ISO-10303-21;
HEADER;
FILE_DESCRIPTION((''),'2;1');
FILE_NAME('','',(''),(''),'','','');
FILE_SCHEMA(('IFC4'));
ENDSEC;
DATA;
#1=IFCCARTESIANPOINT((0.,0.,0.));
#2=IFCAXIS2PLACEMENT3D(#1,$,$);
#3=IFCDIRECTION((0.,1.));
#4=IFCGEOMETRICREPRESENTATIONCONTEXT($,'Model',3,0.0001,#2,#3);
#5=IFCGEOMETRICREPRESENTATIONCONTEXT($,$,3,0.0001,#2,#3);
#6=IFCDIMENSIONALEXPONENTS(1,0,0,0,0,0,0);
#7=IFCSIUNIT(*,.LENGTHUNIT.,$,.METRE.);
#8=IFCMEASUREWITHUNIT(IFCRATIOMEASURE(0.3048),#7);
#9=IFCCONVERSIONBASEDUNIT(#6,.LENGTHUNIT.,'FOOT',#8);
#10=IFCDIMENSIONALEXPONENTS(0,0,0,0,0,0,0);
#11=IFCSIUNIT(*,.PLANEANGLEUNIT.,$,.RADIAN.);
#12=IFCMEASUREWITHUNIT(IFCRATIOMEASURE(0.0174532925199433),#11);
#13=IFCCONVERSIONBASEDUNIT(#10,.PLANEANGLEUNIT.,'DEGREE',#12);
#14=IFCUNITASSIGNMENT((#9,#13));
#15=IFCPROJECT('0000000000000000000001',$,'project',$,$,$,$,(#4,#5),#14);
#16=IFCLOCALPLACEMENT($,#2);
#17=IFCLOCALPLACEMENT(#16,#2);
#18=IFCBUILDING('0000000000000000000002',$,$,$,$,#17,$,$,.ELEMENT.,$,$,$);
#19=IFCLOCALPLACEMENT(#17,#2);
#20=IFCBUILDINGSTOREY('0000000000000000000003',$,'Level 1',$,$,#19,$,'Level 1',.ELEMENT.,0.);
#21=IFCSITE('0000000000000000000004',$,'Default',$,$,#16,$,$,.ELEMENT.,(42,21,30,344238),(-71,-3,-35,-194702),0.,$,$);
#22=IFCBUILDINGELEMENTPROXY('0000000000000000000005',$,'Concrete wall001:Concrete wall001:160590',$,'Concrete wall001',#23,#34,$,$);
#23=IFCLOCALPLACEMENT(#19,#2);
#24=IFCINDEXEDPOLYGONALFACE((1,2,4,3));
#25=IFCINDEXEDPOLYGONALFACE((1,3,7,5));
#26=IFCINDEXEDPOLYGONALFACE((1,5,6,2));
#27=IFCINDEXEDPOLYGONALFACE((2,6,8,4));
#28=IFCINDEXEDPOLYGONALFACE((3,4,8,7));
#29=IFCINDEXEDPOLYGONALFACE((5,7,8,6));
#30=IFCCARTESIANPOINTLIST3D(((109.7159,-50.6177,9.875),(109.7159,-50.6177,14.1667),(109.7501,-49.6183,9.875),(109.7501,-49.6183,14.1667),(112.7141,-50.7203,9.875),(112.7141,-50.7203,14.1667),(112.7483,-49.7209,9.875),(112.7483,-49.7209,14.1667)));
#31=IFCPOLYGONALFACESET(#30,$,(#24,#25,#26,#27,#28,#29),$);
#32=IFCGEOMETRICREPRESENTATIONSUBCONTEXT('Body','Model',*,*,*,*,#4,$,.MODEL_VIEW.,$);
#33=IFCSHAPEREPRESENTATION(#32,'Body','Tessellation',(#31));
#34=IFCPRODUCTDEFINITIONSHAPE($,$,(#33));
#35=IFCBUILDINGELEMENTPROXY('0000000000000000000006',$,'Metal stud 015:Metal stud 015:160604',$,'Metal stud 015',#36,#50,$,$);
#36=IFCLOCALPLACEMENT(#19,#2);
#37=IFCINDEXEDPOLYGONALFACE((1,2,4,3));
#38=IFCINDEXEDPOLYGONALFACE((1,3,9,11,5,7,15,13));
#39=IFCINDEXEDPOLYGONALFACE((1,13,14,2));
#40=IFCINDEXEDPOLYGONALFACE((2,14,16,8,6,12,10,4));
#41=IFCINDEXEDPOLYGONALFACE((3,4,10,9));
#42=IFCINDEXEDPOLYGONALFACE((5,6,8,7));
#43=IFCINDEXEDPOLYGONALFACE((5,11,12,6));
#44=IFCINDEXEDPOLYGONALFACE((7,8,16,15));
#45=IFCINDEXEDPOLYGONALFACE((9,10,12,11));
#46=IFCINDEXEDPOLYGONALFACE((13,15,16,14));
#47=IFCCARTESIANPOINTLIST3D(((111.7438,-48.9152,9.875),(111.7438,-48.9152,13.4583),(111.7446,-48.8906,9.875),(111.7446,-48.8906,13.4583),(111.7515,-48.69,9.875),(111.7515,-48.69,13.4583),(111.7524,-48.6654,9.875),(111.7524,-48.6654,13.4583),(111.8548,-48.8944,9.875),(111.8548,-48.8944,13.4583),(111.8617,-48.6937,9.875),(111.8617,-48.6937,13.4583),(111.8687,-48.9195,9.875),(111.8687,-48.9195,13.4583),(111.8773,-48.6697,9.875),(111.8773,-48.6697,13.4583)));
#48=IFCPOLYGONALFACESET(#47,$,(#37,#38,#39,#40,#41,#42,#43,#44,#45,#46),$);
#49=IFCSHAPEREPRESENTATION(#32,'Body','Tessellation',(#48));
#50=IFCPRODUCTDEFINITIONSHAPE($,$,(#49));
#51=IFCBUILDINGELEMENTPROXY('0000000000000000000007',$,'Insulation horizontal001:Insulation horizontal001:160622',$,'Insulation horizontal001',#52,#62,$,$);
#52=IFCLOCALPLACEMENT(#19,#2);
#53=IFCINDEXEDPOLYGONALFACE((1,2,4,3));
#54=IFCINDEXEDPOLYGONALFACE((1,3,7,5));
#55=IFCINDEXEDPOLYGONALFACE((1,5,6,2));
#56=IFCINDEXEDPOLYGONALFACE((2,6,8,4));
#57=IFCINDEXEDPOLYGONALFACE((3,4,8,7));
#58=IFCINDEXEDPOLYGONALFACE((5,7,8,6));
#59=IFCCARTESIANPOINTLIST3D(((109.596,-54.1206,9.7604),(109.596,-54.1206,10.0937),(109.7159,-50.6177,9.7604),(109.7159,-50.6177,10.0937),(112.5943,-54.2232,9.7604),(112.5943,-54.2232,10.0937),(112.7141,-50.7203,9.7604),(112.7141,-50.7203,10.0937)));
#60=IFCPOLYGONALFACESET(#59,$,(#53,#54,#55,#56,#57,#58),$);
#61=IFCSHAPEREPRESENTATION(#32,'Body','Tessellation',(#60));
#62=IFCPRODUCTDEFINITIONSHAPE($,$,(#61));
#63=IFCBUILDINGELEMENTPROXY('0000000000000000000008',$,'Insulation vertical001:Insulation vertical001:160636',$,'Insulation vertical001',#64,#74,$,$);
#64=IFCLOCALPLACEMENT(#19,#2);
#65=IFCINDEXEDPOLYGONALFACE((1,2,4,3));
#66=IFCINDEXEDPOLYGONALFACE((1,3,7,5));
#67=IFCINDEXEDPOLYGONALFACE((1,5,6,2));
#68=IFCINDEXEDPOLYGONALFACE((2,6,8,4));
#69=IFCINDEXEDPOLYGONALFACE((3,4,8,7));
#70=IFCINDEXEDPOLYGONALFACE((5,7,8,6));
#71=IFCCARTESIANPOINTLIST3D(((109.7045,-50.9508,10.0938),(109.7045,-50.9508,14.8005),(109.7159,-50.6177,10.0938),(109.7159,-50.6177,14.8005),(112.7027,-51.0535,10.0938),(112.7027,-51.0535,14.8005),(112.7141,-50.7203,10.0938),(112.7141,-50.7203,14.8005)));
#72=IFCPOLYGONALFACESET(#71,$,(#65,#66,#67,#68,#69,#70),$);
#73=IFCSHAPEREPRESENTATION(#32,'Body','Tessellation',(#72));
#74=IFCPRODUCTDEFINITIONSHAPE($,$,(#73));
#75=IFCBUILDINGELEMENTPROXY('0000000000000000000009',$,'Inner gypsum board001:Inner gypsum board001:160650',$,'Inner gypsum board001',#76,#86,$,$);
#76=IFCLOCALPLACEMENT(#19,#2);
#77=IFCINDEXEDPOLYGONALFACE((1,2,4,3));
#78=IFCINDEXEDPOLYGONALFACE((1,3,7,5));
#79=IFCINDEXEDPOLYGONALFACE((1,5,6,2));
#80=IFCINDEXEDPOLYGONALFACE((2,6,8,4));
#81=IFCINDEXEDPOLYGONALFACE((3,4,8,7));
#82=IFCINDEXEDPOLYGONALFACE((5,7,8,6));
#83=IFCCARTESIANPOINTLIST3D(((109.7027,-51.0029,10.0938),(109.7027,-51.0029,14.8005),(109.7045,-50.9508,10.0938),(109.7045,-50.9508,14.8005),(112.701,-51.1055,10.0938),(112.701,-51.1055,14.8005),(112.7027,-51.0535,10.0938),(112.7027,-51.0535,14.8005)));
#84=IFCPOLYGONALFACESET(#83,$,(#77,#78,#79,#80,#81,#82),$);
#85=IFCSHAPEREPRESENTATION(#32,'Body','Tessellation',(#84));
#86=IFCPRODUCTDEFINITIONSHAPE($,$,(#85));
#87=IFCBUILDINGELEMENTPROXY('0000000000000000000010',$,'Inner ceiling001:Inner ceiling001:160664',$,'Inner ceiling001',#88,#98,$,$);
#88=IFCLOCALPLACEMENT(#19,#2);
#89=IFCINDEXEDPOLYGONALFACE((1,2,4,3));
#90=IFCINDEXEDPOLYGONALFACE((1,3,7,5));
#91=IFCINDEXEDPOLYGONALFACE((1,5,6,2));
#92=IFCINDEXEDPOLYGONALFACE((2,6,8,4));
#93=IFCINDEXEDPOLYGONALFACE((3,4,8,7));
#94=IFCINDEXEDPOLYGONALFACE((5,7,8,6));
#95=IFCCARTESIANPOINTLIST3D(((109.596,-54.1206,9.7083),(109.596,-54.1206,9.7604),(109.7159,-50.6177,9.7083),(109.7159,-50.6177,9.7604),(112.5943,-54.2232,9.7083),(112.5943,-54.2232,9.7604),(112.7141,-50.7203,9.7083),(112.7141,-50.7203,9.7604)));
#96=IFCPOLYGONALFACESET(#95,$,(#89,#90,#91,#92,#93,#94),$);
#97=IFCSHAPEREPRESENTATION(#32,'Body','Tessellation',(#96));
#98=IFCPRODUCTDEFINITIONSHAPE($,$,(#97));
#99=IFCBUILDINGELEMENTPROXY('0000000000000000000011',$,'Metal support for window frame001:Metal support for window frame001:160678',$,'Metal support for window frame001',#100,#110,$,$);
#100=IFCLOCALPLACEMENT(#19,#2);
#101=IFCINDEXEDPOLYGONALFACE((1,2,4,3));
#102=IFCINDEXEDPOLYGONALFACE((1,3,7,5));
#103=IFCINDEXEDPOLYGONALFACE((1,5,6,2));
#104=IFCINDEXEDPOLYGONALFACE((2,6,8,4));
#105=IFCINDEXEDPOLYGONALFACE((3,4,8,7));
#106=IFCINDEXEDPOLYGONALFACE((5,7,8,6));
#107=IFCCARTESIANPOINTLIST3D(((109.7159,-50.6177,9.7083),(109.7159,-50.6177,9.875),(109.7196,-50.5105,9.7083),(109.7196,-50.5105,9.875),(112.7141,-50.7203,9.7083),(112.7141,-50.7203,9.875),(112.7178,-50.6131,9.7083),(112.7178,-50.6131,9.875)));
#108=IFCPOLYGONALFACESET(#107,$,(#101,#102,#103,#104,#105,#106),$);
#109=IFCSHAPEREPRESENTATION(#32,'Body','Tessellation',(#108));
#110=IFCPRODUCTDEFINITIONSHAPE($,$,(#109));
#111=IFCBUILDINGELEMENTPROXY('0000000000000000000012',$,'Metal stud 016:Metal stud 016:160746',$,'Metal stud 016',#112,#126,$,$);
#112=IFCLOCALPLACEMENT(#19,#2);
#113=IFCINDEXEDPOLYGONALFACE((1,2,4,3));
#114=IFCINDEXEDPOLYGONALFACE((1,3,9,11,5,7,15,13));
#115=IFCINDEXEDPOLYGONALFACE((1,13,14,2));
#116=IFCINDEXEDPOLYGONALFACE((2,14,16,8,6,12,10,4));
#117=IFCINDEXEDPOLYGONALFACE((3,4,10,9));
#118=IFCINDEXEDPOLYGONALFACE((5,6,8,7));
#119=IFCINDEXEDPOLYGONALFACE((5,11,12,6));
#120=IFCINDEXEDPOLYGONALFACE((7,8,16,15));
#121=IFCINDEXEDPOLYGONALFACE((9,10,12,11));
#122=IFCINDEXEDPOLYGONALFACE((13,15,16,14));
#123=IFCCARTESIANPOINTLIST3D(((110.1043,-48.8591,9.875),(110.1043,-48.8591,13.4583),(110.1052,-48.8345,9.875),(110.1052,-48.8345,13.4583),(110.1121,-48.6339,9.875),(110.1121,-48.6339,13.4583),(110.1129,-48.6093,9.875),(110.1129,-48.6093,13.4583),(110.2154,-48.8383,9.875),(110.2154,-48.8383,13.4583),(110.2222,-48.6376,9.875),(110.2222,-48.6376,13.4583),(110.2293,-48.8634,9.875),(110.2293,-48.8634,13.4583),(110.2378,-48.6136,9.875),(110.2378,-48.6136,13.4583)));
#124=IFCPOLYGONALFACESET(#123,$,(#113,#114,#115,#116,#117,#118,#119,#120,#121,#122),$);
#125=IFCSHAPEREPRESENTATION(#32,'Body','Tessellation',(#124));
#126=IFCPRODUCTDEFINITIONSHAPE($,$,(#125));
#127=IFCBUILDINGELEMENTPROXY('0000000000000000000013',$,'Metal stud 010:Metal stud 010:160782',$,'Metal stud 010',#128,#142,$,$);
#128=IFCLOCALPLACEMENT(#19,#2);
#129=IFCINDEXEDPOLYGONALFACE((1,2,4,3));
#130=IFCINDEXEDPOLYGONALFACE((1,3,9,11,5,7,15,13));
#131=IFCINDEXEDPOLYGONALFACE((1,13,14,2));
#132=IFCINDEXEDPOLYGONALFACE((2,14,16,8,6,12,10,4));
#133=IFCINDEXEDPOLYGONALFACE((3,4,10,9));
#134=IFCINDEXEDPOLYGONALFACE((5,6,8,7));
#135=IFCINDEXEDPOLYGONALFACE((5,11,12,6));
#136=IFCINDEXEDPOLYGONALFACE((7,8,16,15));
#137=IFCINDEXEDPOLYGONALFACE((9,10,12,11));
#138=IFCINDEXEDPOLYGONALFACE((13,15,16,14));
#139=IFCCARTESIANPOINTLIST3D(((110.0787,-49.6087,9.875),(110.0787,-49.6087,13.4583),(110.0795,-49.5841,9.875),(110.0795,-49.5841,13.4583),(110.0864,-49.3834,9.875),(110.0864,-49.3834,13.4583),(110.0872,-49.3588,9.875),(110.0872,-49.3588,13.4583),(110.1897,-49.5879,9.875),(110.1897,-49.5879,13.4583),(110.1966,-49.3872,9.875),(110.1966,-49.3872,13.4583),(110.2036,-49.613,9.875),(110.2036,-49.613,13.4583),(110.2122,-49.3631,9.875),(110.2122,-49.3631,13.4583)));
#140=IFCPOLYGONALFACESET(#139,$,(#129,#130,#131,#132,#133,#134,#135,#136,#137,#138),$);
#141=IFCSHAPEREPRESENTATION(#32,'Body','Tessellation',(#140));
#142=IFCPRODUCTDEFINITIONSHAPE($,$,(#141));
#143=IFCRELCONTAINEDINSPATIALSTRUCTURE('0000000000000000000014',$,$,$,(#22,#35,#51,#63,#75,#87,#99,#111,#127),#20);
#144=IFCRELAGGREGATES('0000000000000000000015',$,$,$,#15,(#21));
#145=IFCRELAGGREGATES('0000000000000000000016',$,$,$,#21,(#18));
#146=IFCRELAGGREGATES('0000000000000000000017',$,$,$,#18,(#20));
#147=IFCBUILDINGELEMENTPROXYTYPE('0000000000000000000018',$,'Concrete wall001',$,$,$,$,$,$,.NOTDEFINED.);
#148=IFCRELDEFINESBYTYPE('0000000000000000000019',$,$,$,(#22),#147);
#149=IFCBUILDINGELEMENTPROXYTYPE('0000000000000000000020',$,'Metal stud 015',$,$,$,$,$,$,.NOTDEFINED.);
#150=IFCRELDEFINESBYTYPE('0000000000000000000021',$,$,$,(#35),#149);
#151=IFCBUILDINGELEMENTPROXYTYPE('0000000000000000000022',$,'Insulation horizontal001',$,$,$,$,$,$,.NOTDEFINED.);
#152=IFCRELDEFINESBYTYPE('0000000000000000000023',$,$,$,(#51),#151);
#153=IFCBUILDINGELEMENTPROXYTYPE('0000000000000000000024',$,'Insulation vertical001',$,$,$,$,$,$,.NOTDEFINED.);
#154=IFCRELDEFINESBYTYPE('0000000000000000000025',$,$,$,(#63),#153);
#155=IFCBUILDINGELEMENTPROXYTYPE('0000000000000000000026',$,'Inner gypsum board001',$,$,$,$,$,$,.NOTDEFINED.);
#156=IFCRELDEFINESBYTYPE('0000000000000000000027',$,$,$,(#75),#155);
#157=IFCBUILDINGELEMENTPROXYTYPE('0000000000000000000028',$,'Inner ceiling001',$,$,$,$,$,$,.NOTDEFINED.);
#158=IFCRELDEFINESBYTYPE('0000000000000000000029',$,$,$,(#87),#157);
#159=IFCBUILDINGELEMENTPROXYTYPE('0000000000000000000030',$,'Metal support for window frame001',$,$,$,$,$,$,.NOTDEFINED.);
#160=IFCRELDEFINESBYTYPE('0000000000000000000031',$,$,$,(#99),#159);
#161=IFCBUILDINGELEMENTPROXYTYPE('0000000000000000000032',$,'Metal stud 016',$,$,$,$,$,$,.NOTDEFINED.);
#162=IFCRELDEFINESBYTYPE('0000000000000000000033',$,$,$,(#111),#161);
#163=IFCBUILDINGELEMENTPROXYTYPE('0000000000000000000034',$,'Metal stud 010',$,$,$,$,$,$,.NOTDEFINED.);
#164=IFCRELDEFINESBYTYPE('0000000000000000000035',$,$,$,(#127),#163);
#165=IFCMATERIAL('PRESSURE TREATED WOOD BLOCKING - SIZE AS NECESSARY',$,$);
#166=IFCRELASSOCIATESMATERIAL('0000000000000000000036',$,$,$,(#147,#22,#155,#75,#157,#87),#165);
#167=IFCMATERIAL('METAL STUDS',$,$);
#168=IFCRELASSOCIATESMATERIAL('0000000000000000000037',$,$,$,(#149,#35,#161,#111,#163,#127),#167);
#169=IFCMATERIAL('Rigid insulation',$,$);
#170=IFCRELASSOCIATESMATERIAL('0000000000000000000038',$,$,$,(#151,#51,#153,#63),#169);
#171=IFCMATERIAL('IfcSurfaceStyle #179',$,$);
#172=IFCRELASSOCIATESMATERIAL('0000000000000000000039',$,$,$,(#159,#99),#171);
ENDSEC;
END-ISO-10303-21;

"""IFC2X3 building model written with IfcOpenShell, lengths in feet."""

from ifc_helpers import new_model, entity, si_unit, converted_unit, direction, frame, frame_2d, origin, origin_2d_with_axis, place, context, subcontext, project, spatial, polyline, rectangle, outline, extrude, source, transform, mapped, material, type_object, type_shapes, element, save


model = new_model("IFC2X3")

# Units and contexts
model_context = context("Model", 3, precision=0.0001, world=origin(), true_north=direction((0.0, 1.0)))
context_of_model = context(None, 3, precision=0.0001, world=origin(), true_north=direction((0.0, 1.0)))
body_context = subcontext(model_context, "Body", "Model", "MODEL_VIEW")
ifc_project = project(units=[converted_unit("LENGTHUNIT", "FOOT", entity("IfcRatioMeasure", 0.3048), si_unit("LENGTHUNIT", "METRE"), dimensions=[1, 0, 0, 0, 0, 0, 0]), converted_unit("PLANEANGLEUNIT", "DEGREE", entity("IfcRatioMeasure", 0.0174532925199433), si_unit("PLANEANGLEUNIT", "RADIAN"), dimensions=[0, 0, 0, 0, 0, 0, 0])], contexts=[model_context, context_of_model])

# Site, building, storey
site_placement = place(None, origin())
site = spatial("IfcSite", under=ifc_project, at=site_placement, Name="Default", CompositionType="ELEMENT", RefLatitude=(42, 21, 30, 344238), RefLongitude=(-71, -3, -35, -194702), RefElevation=0.0)
building_placement = place(site_placement, origin())
building = spatial("IfcBuilding", under=site, at=building_placement, CompositionType="ELEMENT")
storey_placement = place(building_placement, origin())
storey = spatial("IfcBuildingStorey", under=building, at=storey_placement, Name="Level 1", LongName="Level 1", CompositionType="ELEMENT", Elevation=0.0)

# Building element proxies
ifc_material_1 = material(Name="PRESSURE TREATED WOOD BLOCKING - SIZE AS NECESSARY")
ifc_material_2 = material(Name="IfcSurfaceStyle #179")
building_element_proxy_type_1 = type_object("IfcBuildingElementProxyType", Name="Concrete wall001", PredefinedType="NOTDEFINED", material=ifc_material_1)
shared_shape_1 = source(origin(), body_context, "Body", "SweptSolid", [
    extrude(rectangle(XDim=3.0, YDim=1.0, at=origin_2d_with_axis()), frame((111.2321, -50.1693, 9.875), z_axis=(0.0, 0.0, 1.0), x_axis=(-0.999415, 0.034202, 0.0)), (0.0, 0.0, 1.0), 4.2917),
])
type_shapes(building_element_proxy_type_1, [shared_shape_1])
proxy_1_placement = place(storey_placement, origin())
element("IfcBuildingElementProxy", 1, at=proxy_1_placement, inside=storey, type_object=building_element_proxy_type_1, material=ifc_material_1, Name="Concrete wall001:Concrete wall001:160590", ObjectType="Concrete wall001", context=body_context, shape_type="MappedRepresentation", body=[
    mapped(shared_shape_1, transform((0.0, 0.0, 0.0), scale=1.0)),
])
ifc_material_3 = material(Name="METAL STUDS")
building_element_proxy_type_2 = type_object("IfcBuildingElementProxyType", Name="Metal stud 015", PredefinedType="NOTDEFINED", material=ifc_material_3)
shared_shape_2 = source(origin(), body_context, "Body", "SweptSolid", [
    extrude(outline(polyline([(-0.0662, -0.125), (0.0588, -0.125), (0.0588, -0.1004), (-0.0514, -0.1004), (-0.0514, 0.1004), (0.0588, 0.1004), (0.0588, 0.125), (-0.0662, 0.125), (-0.0662, -0.125)])), frame((111.8069, -48.7923, 9.875), z_axis=(0.0, 0.0, 1.0), x_axis=(-0.999415, 0.034202, 0.0)), (0.0, 0.0, 1.0), 3.5833),
])
type_shapes(building_element_proxy_type_2, [shared_shape_2])
proxy_2_placement = place(storey_placement, origin())
element("IfcBuildingElementProxy", 2, at=proxy_2_placement, inside=storey, type_object=building_element_proxy_type_2, material=ifc_material_3, Name="Metal stud 015:Metal stud 015:160604", ObjectType="Metal stud 015", context=body_context, shape_type="MappedRepresentation", body=[
    mapped(shared_shape_2, transform((0.0, 0.0, 0.0), scale=1.0)),
])
ifc_material_4 = material(Name="Rigid insulation")
building_element_proxy_type_3 = type_object("IfcBuildingElementProxyType", Name="Insulation horizontal001", PredefinedType="NOTDEFINED", material=ifc_material_4)
shared_shape_3 = source(origin(), body_context, "Body", "SweptSolid", [
    extrude(rectangle(XDim=3.0, YDim=3.505, at=frame_2d((0.0, 0.0), x_axis=(1.0, 0.0))), frame((111.1551, -52.4205, 9.7604), z_axis=(0.0, 0.0, 1.0), x_axis=(-0.999415, 0.034202, 0.0)), (0.0, 0.0, 1.0), 0.3333),
])
type_shapes(building_element_proxy_type_3, [shared_shape_3])
proxy_3_placement = place(storey_placement, origin())
element("IfcBuildingElementProxy", 3, at=proxy_3_placement, inside=storey, type_object=building_element_proxy_type_3, material=ifc_material_4, Name="Insulation horizontal001:Insulation horizontal001:160622", ObjectType="Insulation horizontal001", context=body_context, shape_type="MappedRepresentation", body=[
    mapped(shared_shape_3, transform((0.0, 0.0, 0.0), scale=1.0)),
])
building_element_proxy_type_4 = type_object("IfcBuildingElementProxyType", Name="Insulation vertical001", PredefinedType="NOTDEFINED", material=ifc_material_4)
shared_shape_4 = source(origin(), body_context, "Body", "SweptSolid", [
    extrude(rectangle(XDim=3.0, YDim=0.3333, at=frame_2d((0.0, 0.0), x_axis=(1.0, 0.0))), frame((111.2093, -50.8356, 10.0938), z_axis=(0.0, 0.0, 1.0), x_axis=(-0.999415, 0.034202, 0.0)), (0.0, 0.0, 1.0), 4.7068),
])
type_shapes(building_element_proxy_type_4, [shared_shape_4])
proxy_4_placement = place(storey_placement, origin())
element("IfcBuildingElementProxy", 4, at=proxy_4_placement, inside=storey, type_object=building_element_proxy_type_4, material=ifc_material_4, Name="Insulation vertical001:Insulation vertical001:160636", ObjectType="Insulation vertical001", context=body_context, shape_type="MappedRepresentation", body=[
    mapped(shared_shape_4, transform((0.0, 0.0, 0.0), scale=1.0)),
])
building_element_proxy_type_5 = type_object("IfcBuildingElementProxyType", Name="Inner gypsum board001", PredefinedType="NOTDEFINED", material=ifc_material_1)
shared_shape_5 = source(origin(), body_context, "Body", "SweptSolid", [
    extrude(rectangle(XDim=3.0, YDim=0.0521, at=frame_2d((0.0, 0.0), x_axis=(1.0, 0.0))), frame((111.2027, -51.0282, 10.0938), z_axis=(0.0, 0.0, 1.0), x_axis=(-0.999415, 0.034202, 0.0)), (0.0, 0.0, 1.0), 4.7068),
])
type_shapes(building_element_proxy_type_5, [shared_shape_5])
proxy_5_placement = place(storey_placement, origin())
element("IfcBuildingElementProxy", 5, at=proxy_5_placement, inside=storey, type_object=building_element_proxy_type_5, material=ifc_material_1, Name="Inner gypsum board001:Inner gypsum board001:160650", ObjectType="Inner gypsum board001", context=body_context, shape_type="MappedRepresentation", body=[
    mapped(shared_shape_5, transform((0.0, 0.0, 0.0), scale=1.0)),
])
building_element_proxy_type_6 = type_object("IfcBuildingElementProxyType", Name="Inner ceiling001", PredefinedType="NOTDEFINED", material=ifc_material_1)
shared_shape_6 = source(origin(), body_context, "Body", "SweptSolid", [
    extrude(rectangle(XDim=3.0, YDim=3.505, at=frame_2d((0.0, 0.0), x_axis=(1.0, 0.0))), frame((111.1551, -52.4205, 9.7083), z_axis=(0.0, 0.0, 1.0), x_axis=(-0.999415, 0.034202, 0.0)), (0.0, 0.0, 1.0), 0.0521),
])
type_shapes(building_element_proxy_type_6, [shared_shape_6])
proxy_6_placement = place(storey_placement, origin())
element("IfcBuildingElementProxy", 6, at=proxy_6_placement, inside=storey, type_object=building_element_proxy_type_6, material=ifc_material_1, Name="Inner ceiling001:Inner ceiling001:160664", ObjectType="Inner ceiling001", context=body_context, shape_type="MappedRepresentation", body=[
    mapped(shared_shape_6, transform((0.0, 0.0, 0.0), scale=1.0)),
])
building_element_proxy_type_7 = type_object("IfcBuildingElementProxyType", Name="Metal support for window frame001", PredefinedType="NOTDEFINED", material=ifc_material_2)
shared_shape_7 = source(origin(), body_context, "Body", "SweptSolid", [
    extrude(rectangle(XDim=3.0, YDim=0.1073, at=frame_2d((0.0, 0.0), x_axis=(1.0, 0.0))), frame((111.2168, -50.6154, 9.7083), z_axis=(0.0, 0.0, 1.0), x_axis=(-0.999415, 0.034202, 0.0)), (0.0, 0.0, 1.0), 0.1667),
])
type_shapes(building_element_proxy_type_7, [shared_shape_7])
proxy_7_placement = place(storey_placement, origin())
element("IfcBuildingElementProxy", 7, at=proxy_7_placement, inside=storey, type_object=building_element_proxy_type_7, material=ifc_material_2, Name="Metal support for window frame001:Metal support for window frame001:160678", ObjectType="Metal support for window frame001", context=body_context, shape_type="MappedRepresentation", body=[
    mapped(shared_shape_7, transform((0.0, 0.0, 0.0), scale=1.0)),
])
building_element_proxy_type_8 = type_object("IfcBuildingElementProxyType", Name="Metal stud 016", PredefinedType="NOTDEFINED", material=ifc_material_3)
shared_shape_8 = source(origin(), body_context, "Body", "SweptSolid", [
    extrude(outline(polyline([(-0.0662, -0.125), (0.0588, -0.125), (0.0588, -0.1004), (-0.0514, -0.1004), (-0.0514, 0.1004), (0.0588, 0.1004), (0.0588, 0.125), (-0.0662, 0.125), (-0.0662, -0.125)])), frame((110.1674, -48.7362, 9.875), z_axis=(0.0, 0.0, 1.0), x_axis=(-0.999415, 0.034202, 0.0)), (0.0, 0.0, 1.0), 3.5833),
])
type_shapes(building_element_proxy_type_8, [shared_shape_8])
proxy_8_placement = place(storey_placement, origin())
element("IfcBuildingElementProxy", 8, at=proxy_8_placement, inside=storey, type_object=building_element_proxy_type_8, material=ifc_material_3, Name="Metal stud 016:Metal stud 016:160746", ObjectType="Metal stud 016", context=body_context, shape_type="MappedRepresentation", body=[
    mapped(shared_shape_8, transform((0.0, 0.0, 0.0), scale=1.0)),
])
building_element_proxy_type_9 = type_object("IfcBuildingElementProxyType", Name="Metal stud 010", PredefinedType="NOTDEFINED", material=ifc_material_3)
shared_shape_9 = source(origin(), body_context, "Body", "SweptSolid", [
    extrude(outline(polyline([(-0.0662, -0.125), (0.0588, -0.125), (0.0588, -0.1004), (-0.0514, -0.1004), (-0.0514, 0.1004), (0.0588, 0.1004), (0.0588, 0.125), (-0.0662, 0.125), (-0.0662, -0.125)])), frame((110.1417, -49.4858, 9.875), z_axis=(0.0, 0.0, 1.0), x_axis=(-0.999415, 0.034202, 0.0)), (0.0, 0.0, 1.0), 3.5833),
])
type_shapes(building_element_proxy_type_9, [shared_shape_9])
proxy_9_placement = place(storey_placement, origin())
element("IfcBuildingElementProxy", 9, at=proxy_9_placement, inside=storey, type_object=building_element_proxy_type_9, material=ifc_material_3, Name="Metal stud 010:Metal stud 010:160782", ObjectType="Metal stud 010", context=body_context, shape_type="MappedRepresentation", body=[
    mapped(shared_shape_9, transform((0.0, 0.0, 0.0), scale=1.0)),
])

save(model, "model.ifc")
